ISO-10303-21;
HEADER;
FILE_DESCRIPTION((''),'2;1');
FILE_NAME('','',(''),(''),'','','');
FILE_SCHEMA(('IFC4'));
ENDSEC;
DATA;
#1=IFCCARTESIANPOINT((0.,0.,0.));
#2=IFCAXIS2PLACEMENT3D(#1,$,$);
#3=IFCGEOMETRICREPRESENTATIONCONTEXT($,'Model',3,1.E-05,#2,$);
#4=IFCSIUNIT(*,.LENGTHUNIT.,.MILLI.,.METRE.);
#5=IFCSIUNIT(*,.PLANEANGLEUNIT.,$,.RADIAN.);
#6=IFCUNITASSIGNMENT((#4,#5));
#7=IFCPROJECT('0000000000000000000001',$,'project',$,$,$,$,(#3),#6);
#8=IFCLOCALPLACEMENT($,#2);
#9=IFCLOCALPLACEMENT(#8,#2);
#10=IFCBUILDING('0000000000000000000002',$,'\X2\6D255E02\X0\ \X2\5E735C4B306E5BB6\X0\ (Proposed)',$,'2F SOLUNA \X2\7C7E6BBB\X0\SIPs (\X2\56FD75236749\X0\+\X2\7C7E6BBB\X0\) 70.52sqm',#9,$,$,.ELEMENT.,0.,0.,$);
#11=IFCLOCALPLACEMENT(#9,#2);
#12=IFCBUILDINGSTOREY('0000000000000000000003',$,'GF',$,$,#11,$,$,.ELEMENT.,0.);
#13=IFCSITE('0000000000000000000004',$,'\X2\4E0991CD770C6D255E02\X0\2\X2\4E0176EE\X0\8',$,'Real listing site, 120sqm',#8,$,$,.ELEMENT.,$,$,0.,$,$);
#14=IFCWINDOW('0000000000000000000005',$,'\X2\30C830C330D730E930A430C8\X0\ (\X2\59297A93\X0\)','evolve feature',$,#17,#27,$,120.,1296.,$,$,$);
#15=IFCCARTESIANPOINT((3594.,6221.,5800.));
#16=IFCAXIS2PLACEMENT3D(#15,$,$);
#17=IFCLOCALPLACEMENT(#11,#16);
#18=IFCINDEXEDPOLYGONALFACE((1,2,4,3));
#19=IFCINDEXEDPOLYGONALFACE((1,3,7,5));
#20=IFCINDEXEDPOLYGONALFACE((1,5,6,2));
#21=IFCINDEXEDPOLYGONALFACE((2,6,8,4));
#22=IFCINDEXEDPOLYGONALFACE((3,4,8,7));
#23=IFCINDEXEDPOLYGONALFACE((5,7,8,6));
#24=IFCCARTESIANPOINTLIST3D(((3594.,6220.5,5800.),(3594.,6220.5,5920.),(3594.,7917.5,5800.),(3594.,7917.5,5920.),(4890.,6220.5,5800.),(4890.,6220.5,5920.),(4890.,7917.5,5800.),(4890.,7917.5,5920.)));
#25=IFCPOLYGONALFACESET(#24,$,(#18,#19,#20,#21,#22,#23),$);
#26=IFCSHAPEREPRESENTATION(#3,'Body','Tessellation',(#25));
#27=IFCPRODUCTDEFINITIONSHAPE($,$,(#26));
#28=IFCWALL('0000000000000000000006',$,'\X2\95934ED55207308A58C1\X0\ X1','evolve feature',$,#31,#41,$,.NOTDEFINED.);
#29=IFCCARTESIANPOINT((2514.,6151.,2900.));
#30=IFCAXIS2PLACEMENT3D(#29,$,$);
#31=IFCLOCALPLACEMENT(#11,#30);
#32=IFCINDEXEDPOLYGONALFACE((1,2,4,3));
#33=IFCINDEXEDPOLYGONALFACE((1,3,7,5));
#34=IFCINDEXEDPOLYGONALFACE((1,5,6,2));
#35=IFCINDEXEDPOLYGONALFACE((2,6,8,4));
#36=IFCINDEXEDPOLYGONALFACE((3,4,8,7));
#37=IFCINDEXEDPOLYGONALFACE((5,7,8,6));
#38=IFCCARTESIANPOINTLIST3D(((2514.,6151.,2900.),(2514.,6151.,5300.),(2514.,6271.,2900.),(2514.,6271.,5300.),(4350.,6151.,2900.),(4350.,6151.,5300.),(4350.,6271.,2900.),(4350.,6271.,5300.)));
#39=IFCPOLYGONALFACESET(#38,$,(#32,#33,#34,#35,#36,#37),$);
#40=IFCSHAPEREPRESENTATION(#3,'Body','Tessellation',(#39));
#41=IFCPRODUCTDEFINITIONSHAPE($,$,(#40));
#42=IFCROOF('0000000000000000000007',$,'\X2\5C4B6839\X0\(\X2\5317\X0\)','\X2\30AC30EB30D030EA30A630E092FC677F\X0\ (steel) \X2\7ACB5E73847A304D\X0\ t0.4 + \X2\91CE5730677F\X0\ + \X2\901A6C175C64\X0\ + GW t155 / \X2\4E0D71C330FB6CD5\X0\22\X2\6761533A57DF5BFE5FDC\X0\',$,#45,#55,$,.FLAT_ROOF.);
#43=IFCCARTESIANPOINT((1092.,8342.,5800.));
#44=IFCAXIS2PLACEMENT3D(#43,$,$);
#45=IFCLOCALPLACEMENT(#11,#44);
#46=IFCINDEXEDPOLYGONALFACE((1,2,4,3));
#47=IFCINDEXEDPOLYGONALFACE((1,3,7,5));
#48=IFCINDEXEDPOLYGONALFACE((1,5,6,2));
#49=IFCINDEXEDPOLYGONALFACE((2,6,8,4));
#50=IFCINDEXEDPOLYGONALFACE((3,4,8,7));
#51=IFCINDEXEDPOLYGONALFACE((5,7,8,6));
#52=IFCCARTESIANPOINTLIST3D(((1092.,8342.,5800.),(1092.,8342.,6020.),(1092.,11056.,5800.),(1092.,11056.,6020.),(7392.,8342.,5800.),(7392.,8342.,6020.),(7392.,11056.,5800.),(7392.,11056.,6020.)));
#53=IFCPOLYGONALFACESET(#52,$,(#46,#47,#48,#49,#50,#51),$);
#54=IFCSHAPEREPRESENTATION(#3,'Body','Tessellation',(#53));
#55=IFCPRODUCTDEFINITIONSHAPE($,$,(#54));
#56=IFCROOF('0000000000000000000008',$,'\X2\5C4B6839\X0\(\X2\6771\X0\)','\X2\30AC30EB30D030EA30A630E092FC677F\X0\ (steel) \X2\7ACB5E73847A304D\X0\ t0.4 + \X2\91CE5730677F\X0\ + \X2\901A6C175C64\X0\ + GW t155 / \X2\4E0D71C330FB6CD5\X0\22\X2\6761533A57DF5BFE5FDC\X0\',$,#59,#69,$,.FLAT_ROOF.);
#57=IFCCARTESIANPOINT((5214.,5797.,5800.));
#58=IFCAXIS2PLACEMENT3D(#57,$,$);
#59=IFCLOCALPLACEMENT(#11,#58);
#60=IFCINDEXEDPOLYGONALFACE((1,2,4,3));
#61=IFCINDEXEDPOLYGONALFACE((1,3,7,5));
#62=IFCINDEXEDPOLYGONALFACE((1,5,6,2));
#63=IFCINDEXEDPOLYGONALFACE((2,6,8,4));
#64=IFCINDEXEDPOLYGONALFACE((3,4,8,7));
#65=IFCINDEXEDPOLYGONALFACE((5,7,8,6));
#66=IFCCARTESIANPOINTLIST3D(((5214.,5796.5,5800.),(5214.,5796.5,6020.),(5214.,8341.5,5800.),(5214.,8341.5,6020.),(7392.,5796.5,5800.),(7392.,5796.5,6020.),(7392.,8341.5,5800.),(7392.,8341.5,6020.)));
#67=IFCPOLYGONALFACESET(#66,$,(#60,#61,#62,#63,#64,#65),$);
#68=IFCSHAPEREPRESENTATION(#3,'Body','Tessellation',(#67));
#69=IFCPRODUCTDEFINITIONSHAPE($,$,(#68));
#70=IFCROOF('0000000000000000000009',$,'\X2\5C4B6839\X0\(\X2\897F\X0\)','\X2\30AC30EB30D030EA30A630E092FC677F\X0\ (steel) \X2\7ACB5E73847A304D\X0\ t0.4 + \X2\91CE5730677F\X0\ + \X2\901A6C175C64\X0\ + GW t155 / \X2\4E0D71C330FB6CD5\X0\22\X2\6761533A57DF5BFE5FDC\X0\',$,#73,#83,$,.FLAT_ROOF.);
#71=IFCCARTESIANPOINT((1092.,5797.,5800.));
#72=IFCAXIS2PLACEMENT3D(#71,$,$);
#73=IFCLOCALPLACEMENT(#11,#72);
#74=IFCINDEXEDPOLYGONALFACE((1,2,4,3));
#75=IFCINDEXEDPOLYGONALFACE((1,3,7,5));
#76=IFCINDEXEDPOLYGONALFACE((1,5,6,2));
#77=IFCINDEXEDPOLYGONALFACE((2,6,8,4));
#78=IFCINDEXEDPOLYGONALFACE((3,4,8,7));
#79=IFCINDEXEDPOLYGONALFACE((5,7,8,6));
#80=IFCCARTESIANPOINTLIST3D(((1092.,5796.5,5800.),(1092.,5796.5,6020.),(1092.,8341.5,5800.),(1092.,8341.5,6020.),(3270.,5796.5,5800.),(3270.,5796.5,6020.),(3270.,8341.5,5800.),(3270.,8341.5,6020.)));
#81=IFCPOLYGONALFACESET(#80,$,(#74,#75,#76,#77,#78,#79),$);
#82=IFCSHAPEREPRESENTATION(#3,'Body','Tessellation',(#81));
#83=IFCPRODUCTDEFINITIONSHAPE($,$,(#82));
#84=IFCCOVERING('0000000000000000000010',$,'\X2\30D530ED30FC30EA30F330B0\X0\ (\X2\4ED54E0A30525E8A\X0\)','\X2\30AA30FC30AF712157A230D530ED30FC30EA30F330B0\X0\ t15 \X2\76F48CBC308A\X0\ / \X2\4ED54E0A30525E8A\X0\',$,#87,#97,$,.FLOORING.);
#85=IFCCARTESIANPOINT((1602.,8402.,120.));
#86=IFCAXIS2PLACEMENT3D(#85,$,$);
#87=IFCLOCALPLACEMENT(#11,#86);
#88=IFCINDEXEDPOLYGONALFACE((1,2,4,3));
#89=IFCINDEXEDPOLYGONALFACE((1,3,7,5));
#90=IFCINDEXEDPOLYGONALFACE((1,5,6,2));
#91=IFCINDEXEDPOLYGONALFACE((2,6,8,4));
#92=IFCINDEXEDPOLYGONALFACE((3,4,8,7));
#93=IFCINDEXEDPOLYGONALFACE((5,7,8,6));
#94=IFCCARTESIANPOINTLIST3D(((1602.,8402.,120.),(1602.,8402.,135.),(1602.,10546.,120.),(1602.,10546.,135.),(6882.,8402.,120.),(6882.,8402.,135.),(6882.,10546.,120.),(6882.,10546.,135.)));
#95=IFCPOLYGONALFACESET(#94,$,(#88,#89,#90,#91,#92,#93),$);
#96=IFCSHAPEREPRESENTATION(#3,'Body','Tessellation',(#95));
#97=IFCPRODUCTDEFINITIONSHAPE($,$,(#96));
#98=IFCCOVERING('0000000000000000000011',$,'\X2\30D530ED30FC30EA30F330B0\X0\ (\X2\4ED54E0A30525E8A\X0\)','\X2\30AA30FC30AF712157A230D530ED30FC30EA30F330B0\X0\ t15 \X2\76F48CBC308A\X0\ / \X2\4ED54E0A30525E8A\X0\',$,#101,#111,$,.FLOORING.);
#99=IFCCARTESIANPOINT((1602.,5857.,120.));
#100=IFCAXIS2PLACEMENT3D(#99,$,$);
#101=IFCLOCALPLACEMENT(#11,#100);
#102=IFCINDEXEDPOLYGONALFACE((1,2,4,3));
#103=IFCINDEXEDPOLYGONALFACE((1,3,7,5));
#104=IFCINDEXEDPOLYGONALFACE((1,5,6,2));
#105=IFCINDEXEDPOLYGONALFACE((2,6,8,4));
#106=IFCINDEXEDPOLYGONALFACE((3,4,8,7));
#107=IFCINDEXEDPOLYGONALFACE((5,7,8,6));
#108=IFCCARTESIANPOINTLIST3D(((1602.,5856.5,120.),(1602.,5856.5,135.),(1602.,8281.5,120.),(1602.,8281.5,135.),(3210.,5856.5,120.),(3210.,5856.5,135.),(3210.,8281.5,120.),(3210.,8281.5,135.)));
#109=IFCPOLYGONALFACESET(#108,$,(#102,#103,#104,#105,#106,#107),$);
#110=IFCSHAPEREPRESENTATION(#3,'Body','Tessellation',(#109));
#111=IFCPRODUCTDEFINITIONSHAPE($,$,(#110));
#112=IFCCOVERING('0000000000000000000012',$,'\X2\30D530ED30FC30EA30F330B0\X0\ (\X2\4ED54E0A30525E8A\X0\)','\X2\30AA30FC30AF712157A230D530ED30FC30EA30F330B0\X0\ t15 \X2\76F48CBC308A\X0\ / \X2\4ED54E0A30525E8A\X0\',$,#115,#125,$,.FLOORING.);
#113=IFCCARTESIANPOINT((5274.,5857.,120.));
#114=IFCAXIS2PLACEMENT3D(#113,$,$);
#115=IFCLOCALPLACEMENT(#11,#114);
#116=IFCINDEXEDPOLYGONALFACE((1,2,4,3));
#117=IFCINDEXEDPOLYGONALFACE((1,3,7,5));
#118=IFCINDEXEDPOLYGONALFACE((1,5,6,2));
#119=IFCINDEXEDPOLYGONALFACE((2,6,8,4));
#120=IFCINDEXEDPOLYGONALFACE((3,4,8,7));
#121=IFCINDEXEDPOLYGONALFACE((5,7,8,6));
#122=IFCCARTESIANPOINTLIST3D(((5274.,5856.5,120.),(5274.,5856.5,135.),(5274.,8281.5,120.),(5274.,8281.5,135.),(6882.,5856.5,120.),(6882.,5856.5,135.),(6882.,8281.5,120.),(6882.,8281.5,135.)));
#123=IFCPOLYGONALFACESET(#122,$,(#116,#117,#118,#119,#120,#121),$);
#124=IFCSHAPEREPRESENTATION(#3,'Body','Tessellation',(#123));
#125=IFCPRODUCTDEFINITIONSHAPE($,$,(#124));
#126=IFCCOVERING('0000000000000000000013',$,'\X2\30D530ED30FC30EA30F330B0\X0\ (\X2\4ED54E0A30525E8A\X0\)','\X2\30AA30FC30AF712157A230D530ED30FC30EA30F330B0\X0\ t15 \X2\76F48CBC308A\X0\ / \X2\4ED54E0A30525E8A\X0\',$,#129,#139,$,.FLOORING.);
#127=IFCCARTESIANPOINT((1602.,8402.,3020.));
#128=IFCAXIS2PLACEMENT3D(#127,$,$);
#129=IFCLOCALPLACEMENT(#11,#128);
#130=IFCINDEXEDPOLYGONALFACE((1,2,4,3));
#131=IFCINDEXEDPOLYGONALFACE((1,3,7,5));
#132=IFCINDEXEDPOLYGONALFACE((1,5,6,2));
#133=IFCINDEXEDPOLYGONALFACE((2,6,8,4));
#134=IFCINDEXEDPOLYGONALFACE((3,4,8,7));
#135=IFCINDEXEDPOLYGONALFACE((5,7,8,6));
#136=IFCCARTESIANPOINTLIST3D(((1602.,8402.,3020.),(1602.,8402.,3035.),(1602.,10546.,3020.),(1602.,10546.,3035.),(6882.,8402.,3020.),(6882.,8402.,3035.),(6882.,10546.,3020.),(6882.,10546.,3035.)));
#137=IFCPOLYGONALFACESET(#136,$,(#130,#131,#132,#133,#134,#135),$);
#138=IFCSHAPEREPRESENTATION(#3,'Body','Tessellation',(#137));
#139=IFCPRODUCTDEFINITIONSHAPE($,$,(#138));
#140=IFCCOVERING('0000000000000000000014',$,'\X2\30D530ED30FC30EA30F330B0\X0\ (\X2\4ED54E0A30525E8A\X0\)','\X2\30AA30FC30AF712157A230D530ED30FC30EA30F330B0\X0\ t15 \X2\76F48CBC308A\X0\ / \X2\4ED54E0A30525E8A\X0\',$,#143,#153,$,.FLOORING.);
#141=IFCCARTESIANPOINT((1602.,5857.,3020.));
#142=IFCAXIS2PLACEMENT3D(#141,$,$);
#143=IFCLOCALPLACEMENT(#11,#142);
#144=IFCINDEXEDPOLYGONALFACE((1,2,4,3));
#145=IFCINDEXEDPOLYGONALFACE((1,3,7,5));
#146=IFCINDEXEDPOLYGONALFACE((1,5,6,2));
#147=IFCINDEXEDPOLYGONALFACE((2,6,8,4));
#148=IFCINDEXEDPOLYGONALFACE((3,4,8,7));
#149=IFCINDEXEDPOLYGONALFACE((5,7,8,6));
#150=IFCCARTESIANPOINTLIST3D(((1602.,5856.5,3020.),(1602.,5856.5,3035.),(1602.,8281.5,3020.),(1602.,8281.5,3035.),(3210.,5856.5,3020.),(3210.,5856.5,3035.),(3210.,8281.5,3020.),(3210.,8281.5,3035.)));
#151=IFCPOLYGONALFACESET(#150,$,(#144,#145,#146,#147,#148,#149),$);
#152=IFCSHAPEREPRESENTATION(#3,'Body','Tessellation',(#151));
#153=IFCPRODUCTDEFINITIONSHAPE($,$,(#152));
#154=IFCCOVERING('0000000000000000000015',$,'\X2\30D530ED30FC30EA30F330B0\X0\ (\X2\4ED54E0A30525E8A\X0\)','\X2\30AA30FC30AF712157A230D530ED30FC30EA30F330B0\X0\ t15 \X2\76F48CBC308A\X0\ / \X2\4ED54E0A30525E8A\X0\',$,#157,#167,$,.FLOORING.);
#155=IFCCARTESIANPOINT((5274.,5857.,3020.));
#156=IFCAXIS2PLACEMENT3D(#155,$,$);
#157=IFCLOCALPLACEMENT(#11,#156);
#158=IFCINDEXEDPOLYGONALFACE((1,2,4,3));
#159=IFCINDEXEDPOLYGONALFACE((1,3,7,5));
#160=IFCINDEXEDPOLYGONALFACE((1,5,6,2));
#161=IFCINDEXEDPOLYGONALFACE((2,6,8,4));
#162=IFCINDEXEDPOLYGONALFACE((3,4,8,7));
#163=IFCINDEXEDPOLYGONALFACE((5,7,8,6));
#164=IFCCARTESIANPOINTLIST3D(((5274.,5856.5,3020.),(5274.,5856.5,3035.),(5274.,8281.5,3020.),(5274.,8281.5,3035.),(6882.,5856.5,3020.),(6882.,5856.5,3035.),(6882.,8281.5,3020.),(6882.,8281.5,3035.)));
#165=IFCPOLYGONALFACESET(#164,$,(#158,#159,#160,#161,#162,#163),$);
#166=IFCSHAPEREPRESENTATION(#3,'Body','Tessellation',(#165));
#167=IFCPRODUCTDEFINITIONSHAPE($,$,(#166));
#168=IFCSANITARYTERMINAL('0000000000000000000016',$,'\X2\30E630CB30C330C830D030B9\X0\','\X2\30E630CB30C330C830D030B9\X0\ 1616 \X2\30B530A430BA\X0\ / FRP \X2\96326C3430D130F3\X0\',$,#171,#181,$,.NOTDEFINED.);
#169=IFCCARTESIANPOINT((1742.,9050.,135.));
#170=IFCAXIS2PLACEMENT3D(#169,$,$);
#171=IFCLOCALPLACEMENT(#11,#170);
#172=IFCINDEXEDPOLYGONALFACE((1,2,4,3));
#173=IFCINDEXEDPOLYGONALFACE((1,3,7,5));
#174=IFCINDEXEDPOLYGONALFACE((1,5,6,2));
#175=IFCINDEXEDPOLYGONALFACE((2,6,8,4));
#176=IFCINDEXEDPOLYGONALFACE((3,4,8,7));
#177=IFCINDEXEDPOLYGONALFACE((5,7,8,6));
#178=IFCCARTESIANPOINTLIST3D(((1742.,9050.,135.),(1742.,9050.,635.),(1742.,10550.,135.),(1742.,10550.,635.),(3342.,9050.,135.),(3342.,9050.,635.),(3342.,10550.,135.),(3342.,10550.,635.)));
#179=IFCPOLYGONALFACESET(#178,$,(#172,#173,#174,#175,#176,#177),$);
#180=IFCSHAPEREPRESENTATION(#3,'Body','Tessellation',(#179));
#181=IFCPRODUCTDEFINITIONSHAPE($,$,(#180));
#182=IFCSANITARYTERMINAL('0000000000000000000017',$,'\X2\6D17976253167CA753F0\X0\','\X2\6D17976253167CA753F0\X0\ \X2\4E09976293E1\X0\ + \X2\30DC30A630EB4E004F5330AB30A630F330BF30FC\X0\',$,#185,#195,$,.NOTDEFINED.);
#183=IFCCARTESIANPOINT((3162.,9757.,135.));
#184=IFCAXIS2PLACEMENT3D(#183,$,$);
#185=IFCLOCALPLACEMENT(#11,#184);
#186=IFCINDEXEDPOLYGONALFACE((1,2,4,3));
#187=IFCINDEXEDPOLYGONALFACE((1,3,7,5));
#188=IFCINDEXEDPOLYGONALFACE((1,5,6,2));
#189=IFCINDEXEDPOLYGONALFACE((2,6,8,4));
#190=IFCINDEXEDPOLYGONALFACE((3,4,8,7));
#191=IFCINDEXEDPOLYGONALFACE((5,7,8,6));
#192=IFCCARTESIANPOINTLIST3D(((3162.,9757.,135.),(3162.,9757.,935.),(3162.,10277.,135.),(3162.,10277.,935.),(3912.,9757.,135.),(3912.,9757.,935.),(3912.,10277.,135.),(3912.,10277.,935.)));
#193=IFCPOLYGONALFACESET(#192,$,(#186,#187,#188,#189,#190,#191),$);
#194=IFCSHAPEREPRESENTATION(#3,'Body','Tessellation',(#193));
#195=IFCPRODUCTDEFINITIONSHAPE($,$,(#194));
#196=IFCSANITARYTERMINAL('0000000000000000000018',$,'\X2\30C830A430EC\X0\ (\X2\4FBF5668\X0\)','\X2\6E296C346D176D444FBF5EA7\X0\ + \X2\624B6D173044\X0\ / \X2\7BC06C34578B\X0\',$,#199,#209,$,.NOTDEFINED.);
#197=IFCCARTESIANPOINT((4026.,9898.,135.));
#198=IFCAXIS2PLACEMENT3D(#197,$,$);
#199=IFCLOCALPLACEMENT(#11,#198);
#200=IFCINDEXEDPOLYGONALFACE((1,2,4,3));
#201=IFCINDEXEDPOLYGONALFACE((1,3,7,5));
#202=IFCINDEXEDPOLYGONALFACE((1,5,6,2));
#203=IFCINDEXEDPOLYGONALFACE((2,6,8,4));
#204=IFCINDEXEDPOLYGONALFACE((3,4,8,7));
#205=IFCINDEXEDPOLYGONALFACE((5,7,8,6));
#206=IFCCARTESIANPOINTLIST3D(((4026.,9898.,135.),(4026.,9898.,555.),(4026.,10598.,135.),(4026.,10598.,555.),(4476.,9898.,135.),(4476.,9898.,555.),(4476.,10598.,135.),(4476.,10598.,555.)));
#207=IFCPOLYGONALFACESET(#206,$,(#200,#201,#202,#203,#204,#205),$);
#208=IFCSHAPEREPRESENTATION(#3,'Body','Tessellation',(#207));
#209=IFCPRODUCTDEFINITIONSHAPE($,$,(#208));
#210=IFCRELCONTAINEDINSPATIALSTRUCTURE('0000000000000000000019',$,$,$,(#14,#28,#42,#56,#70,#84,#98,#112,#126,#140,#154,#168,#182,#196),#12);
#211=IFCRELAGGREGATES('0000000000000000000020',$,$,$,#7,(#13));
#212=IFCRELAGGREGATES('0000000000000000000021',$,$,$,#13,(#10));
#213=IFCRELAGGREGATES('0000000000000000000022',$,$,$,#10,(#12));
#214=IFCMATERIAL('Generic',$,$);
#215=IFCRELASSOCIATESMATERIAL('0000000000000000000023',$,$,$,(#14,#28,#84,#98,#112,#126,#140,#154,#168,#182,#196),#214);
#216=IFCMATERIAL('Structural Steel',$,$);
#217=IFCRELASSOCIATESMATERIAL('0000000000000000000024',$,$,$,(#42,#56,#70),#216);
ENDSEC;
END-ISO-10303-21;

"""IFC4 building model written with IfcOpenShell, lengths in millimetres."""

from ifc_helpers import new_model, si_unit, frame, frame_2d, origin, place, context, project, spatial, rectangle, extrude, material, element, save


model = new_model("IFC4")

# Units and contexts
model_context = context("Model", 3, precision=1e-05, world=origin())
ifc_project = project(units=[si_unit("LENGTHUNIT", "METRE", prefix="MILLI"), si_unit("PLANEANGLEUNIT", "RADIAN")], contexts=[model_context])

# Site, building, storey
site_placement = place(None, origin())
site = spatial("IfcSite", under=ifc_project, at=site_placement, Name="三重県津市2丁目8", ObjectType="Real listing site, 120sqm", CompositionType="ELEMENT", RefElevation=0.0)
building_placement = place(site_placement, origin())
building = spatial("IfcBuilding", under=site, at=building_placement, Name="津市 平屋の家 (Proposed)", ObjectType="2F SOLUNA 籾殻SIPs (国産杉+籾殻) 70.52sqm", CompositionType="ELEMENT", ElevationOfRefHeight=0.0, ElevationOfTerrain=0.0)
storey_placement = place(building_placement, origin())
storey = spatial("IfcBuildingStorey", under=building, at=storey_placement, Name="GF", CompositionType="ELEMENT", Elevation=0.0)

# Window
ifc_material_1 = material(Name="Generic")
window_1_placement = place(storey_placement, frame((3594.0, 6221.0, 5800.0)))
element("IfcWindow", 1, at=window_1_placement, inside=storey, material=ifc_material_1, Name="トップライト (天窓)", Description="evolve feature", OverallHeight=120.0, OverallWidth=1296.0, context=model_context, shape_type="SweptSolid", body=[
    extrude(rectangle(XDim=1296.0, YDim=1697.0, at=frame_2d((648.0, 848.0))), frame((3594.0, 6221.0, 5800.0)), (0.0, 0.0, 1.0), 120.0),
])

# Wall
wall_1_placement = place(storey_placement, frame((2514.0, 6151.0, 2900.0)))
element("IfcWall", 2, at=wall_1_placement, inside=storey, material=ifc_material_1, Name="間仕切り壁 X1", Description="evolve feature", PredefinedType="NOTDEFINED", context=model_context, shape_type="SweptSolid", body=[
    extrude(rectangle(XDim=1836.0, YDim=120.0, at=frame_2d((918.0, 60.0))), frame((2514.0, 6151.0, 2900.0)), (0.0, 0.0, 1.0), 2400.0),
])

# Roofs
ifc_material_2 = material(Name="Structural Steel")
roof_1_placement = place(storey_placement, frame((1092.0, 8342.0, 5800.0)))
element("IfcRoof", 3, at=roof_1_placement, inside=storey, material=ifc_material_2, Name="屋根(北)", Description="ガルバリウム鋼板 (steel) 立平葺き t0.4 + 野地板 + 通気層 + GW t155 / 不燃・法22条区域対応", PredefinedType="FLAT_ROOF", context=model_context, shape_type="SweptSolid", body=[
    extrude(rectangle(XDim=6300.0, YDim=2714.0, at=frame_2d((3150.0, 1357.0))), frame((1092.0, 8342.0, 5800.0)), (0.0, 0.0, 1.0), 220.0),
])
roof_2_placement = place(storey_placement, frame((5214.0, 5797.0, 5800.0)))
element("IfcRoof", 4, at=roof_2_placement, inside=storey, material=ifc_material_2, Name="屋根(東)", Description="ガルバリウム鋼板 (steel) 立平葺き t0.4 + 野地板 + 通気層 + GW t155 / 不燃・法22条区域対応", PredefinedType="FLAT_ROOF", context=model_context, shape_type="SweptSolid", body=[
    extrude(rectangle(XDim=2178.0, YDim=2545.0, at=frame_2d((1089.0, 1272.0))), frame((5214.0, 5797.0, 5800.0)), (0.0, 0.0, 1.0), 220.0),
])
roof_3_placement = place(storey_placement, frame((1092.0, 5797.0, 5800.0)))
element("IfcRoof", 5, at=roof_3_placement, inside=storey, material=ifc_material_2, Name="屋根(西)", Description="ガルバリウム鋼板 (steel) 立平葺き t0.4 + 野地板 + 通気層 + GW t155 / 不燃・法22条区域対応", PredefinedType="FLAT_ROOF", context=model_context, shape_type="SweptSolid", body=[
    extrude(rectangle(XDim=2178.0, YDim=2545.0, at=frame_2d((1089.0, 1272.0))), frame((1092.0, 5797.0, 5800.0)), (0.0, 0.0, 1.0), 220.0),
])

# Coverings
covering_1_placement = place(storey_placement, frame((1602.0, 8402.0, 120.0)))
element("IfcCovering", 6, at=covering_1_placement, inside=storey, material=ifc_material_1, Name="フローリング (仕上げ床)", Description="オーク無垢フローリング t15 直貼り / 仕上げ床", PredefinedType="FLOORING", context=model_context, shape_type="SweptSolid", body=[
    extrude(rectangle(XDim=5280.0, YDim=2144.0, at=frame_2d((2640.0, 1072.0))), frame((1602.0, 8402.0, 120.0)), (0.0, 0.0, 1.0), 15.0),
])
covering_2_placement = place(storey_placement, frame((1602.0, 5857.0, 120.0)))
element("IfcCovering", 7, at=covering_2_placement, inside=storey, material=ifc_material_1, Name="フローリング (仕上げ床)", Description="オーク無垢フローリング t15 直貼り / 仕上げ床", PredefinedType="FLOORING", context=model_context, shape_type="SweptSolid", body=[
    extrude(rectangle(XDim=1608.0, YDim=2425.0, at=frame_2d((804.0, 1212.0))), frame((1602.0, 5857.0, 120.0)), (0.0, 0.0, 1.0), 15.0),
])
covering_3_placement = place(storey_placement, frame((5274.0, 5857.0, 120.0)))
element("IfcCovering", 8, at=covering_3_placement, inside=storey, material=ifc_material_1, Name="フローリング (仕上げ床)", Description="オーク無垢フローリング t15 直貼り / 仕上げ床", PredefinedType="FLOORING", context=model_context, shape_type="SweptSolid", body=[
    extrude(rectangle(XDim=1608.0, YDim=2425.0, at=frame_2d((804.0, 1212.0))), frame((5274.0, 5857.0, 120.0)), (0.0, 0.0, 1.0), 15.0),
])
covering_4_placement = place(storey_placement, frame((1602.0, 8402.0, 3020.0)))
element("IfcCovering", 9, at=covering_4_placement, inside=storey, material=ifc_material_1, Name="フローリング (仕上げ床)", Description="オーク無垢フローリング t15 直貼り / 仕上げ床", PredefinedType="FLOORING", context=model_context, shape_type="SweptSolid", body=[
    extrude(rectangle(XDim=5280.0, YDim=2144.0, at=frame_2d((2640.0, 1072.0))), frame((1602.0, 8402.0, 3020.0)), (0.0, 0.0, 1.0), 15.0),
])
covering_5_placement = place(storey_placement, frame((1602.0, 5857.0, 3020.0)))
element("IfcCovering", 10, at=covering_5_placement, inside=storey, material=ifc_material_1, Name="フローリング (仕上げ床)", Description="オーク無垢フローリング t15 直貼り / 仕上げ床", PredefinedType="FLOORING", context=model_context, shape_type="SweptSolid", body=[
    extrude(rectangle(XDim=1608.0, YDim=2425.0, at=frame_2d((804.0, 1212.0))), frame((1602.0, 5857.0, 3020.0)), (0.0, 0.0, 1.0), 15.0),
])
covering_6_placement = place(storey_placement, frame((5274.0, 5857.0, 3020.0)))
element("IfcCovering", 11, at=covering_6_placement, inside=storey, material=ifc_material_1, Name="フローリング (仕上げ床)", Description="オーク無垢フローリング t15 直貼り / 仕上げ床", PredefinedType="FLOORING", context=model_context, shape_type="SweptSolid", body=[
    extrude(rectangle(XDim=1608.0, YDim=2425.0, at=frame_2d((804.0, 1212.0))), frame((5274.0, 5857.0, 3020.0)), (0.0, 0.0, 1.0), 15.0),
])

# Sanitary terminals
sanitary_terminal_1_placement = place(storey_placement, frame((1742.0, 9050.0, 135.0)))
element("IfcSanitaryTerminal", 12, at=sanitary_terminal_1_placement, inside=storey, material=ifc_material_1, Name="ユニットバス", Description="ユニットバス 1616 サイズ / FRP 防水パン", PredefinedType="NOTDEFINED", context=model_context, shape_type="SweptSolid", body=[
    extrude(rectangle(XDim=1600.0, YDim=1500.0, at=frame_2d((800.0, 750.0))), frame((1742.0, 9050.0, 135.0)), (0.0, 0.0, 1.0), 500.0),
])
sanitary_terminal_2_placement = place(storey_placement, frame((3162.0, 9757.0, 135.0)))
element("IfcSanitaryTerminal", 13, at=sanitary_terminal_2_placement, inside=storey, material=ifc_material_1, Name="洗面化粧台", Description="洗面化粧台 三面鏡 + ボウル一体カウンター", PredefinedType="NOTDEFINED", context=model_context, shape_type="SweptSolid", body=[
    extrude(rectangle(XDim=750.0, YDim=520.0, at=frame_2d((375.0, 260.0))), frame((3162.0, 9757.0, 135.0)), (0.0, 0.0, 1.0), 800.0),
])
sanitary_terminal_3_placement = place(storey_placement, frame((4026.0, 9898.0, 135.0)))
element("IfcSanitaryTerminal", 14, at=sanitary_terminal_3_placement, inside=storey, material=ifc_material_1, Name="トイレ (便器)", Description="温水洗浄便座 + 手洗い / 節水型", PredefinedType="NOTDEFINED", context=model_context, shape_type="SweptSolid", body=[
    extrude(rectangle(XDim=450.0, YDim=700.0, at=frame_2d((225.0, 350.0))), frame((4026.0, 9898.0, 135.0)), (0.0, 0.0, 1.0), 420.0),
])

save(model, "model.ifc")
